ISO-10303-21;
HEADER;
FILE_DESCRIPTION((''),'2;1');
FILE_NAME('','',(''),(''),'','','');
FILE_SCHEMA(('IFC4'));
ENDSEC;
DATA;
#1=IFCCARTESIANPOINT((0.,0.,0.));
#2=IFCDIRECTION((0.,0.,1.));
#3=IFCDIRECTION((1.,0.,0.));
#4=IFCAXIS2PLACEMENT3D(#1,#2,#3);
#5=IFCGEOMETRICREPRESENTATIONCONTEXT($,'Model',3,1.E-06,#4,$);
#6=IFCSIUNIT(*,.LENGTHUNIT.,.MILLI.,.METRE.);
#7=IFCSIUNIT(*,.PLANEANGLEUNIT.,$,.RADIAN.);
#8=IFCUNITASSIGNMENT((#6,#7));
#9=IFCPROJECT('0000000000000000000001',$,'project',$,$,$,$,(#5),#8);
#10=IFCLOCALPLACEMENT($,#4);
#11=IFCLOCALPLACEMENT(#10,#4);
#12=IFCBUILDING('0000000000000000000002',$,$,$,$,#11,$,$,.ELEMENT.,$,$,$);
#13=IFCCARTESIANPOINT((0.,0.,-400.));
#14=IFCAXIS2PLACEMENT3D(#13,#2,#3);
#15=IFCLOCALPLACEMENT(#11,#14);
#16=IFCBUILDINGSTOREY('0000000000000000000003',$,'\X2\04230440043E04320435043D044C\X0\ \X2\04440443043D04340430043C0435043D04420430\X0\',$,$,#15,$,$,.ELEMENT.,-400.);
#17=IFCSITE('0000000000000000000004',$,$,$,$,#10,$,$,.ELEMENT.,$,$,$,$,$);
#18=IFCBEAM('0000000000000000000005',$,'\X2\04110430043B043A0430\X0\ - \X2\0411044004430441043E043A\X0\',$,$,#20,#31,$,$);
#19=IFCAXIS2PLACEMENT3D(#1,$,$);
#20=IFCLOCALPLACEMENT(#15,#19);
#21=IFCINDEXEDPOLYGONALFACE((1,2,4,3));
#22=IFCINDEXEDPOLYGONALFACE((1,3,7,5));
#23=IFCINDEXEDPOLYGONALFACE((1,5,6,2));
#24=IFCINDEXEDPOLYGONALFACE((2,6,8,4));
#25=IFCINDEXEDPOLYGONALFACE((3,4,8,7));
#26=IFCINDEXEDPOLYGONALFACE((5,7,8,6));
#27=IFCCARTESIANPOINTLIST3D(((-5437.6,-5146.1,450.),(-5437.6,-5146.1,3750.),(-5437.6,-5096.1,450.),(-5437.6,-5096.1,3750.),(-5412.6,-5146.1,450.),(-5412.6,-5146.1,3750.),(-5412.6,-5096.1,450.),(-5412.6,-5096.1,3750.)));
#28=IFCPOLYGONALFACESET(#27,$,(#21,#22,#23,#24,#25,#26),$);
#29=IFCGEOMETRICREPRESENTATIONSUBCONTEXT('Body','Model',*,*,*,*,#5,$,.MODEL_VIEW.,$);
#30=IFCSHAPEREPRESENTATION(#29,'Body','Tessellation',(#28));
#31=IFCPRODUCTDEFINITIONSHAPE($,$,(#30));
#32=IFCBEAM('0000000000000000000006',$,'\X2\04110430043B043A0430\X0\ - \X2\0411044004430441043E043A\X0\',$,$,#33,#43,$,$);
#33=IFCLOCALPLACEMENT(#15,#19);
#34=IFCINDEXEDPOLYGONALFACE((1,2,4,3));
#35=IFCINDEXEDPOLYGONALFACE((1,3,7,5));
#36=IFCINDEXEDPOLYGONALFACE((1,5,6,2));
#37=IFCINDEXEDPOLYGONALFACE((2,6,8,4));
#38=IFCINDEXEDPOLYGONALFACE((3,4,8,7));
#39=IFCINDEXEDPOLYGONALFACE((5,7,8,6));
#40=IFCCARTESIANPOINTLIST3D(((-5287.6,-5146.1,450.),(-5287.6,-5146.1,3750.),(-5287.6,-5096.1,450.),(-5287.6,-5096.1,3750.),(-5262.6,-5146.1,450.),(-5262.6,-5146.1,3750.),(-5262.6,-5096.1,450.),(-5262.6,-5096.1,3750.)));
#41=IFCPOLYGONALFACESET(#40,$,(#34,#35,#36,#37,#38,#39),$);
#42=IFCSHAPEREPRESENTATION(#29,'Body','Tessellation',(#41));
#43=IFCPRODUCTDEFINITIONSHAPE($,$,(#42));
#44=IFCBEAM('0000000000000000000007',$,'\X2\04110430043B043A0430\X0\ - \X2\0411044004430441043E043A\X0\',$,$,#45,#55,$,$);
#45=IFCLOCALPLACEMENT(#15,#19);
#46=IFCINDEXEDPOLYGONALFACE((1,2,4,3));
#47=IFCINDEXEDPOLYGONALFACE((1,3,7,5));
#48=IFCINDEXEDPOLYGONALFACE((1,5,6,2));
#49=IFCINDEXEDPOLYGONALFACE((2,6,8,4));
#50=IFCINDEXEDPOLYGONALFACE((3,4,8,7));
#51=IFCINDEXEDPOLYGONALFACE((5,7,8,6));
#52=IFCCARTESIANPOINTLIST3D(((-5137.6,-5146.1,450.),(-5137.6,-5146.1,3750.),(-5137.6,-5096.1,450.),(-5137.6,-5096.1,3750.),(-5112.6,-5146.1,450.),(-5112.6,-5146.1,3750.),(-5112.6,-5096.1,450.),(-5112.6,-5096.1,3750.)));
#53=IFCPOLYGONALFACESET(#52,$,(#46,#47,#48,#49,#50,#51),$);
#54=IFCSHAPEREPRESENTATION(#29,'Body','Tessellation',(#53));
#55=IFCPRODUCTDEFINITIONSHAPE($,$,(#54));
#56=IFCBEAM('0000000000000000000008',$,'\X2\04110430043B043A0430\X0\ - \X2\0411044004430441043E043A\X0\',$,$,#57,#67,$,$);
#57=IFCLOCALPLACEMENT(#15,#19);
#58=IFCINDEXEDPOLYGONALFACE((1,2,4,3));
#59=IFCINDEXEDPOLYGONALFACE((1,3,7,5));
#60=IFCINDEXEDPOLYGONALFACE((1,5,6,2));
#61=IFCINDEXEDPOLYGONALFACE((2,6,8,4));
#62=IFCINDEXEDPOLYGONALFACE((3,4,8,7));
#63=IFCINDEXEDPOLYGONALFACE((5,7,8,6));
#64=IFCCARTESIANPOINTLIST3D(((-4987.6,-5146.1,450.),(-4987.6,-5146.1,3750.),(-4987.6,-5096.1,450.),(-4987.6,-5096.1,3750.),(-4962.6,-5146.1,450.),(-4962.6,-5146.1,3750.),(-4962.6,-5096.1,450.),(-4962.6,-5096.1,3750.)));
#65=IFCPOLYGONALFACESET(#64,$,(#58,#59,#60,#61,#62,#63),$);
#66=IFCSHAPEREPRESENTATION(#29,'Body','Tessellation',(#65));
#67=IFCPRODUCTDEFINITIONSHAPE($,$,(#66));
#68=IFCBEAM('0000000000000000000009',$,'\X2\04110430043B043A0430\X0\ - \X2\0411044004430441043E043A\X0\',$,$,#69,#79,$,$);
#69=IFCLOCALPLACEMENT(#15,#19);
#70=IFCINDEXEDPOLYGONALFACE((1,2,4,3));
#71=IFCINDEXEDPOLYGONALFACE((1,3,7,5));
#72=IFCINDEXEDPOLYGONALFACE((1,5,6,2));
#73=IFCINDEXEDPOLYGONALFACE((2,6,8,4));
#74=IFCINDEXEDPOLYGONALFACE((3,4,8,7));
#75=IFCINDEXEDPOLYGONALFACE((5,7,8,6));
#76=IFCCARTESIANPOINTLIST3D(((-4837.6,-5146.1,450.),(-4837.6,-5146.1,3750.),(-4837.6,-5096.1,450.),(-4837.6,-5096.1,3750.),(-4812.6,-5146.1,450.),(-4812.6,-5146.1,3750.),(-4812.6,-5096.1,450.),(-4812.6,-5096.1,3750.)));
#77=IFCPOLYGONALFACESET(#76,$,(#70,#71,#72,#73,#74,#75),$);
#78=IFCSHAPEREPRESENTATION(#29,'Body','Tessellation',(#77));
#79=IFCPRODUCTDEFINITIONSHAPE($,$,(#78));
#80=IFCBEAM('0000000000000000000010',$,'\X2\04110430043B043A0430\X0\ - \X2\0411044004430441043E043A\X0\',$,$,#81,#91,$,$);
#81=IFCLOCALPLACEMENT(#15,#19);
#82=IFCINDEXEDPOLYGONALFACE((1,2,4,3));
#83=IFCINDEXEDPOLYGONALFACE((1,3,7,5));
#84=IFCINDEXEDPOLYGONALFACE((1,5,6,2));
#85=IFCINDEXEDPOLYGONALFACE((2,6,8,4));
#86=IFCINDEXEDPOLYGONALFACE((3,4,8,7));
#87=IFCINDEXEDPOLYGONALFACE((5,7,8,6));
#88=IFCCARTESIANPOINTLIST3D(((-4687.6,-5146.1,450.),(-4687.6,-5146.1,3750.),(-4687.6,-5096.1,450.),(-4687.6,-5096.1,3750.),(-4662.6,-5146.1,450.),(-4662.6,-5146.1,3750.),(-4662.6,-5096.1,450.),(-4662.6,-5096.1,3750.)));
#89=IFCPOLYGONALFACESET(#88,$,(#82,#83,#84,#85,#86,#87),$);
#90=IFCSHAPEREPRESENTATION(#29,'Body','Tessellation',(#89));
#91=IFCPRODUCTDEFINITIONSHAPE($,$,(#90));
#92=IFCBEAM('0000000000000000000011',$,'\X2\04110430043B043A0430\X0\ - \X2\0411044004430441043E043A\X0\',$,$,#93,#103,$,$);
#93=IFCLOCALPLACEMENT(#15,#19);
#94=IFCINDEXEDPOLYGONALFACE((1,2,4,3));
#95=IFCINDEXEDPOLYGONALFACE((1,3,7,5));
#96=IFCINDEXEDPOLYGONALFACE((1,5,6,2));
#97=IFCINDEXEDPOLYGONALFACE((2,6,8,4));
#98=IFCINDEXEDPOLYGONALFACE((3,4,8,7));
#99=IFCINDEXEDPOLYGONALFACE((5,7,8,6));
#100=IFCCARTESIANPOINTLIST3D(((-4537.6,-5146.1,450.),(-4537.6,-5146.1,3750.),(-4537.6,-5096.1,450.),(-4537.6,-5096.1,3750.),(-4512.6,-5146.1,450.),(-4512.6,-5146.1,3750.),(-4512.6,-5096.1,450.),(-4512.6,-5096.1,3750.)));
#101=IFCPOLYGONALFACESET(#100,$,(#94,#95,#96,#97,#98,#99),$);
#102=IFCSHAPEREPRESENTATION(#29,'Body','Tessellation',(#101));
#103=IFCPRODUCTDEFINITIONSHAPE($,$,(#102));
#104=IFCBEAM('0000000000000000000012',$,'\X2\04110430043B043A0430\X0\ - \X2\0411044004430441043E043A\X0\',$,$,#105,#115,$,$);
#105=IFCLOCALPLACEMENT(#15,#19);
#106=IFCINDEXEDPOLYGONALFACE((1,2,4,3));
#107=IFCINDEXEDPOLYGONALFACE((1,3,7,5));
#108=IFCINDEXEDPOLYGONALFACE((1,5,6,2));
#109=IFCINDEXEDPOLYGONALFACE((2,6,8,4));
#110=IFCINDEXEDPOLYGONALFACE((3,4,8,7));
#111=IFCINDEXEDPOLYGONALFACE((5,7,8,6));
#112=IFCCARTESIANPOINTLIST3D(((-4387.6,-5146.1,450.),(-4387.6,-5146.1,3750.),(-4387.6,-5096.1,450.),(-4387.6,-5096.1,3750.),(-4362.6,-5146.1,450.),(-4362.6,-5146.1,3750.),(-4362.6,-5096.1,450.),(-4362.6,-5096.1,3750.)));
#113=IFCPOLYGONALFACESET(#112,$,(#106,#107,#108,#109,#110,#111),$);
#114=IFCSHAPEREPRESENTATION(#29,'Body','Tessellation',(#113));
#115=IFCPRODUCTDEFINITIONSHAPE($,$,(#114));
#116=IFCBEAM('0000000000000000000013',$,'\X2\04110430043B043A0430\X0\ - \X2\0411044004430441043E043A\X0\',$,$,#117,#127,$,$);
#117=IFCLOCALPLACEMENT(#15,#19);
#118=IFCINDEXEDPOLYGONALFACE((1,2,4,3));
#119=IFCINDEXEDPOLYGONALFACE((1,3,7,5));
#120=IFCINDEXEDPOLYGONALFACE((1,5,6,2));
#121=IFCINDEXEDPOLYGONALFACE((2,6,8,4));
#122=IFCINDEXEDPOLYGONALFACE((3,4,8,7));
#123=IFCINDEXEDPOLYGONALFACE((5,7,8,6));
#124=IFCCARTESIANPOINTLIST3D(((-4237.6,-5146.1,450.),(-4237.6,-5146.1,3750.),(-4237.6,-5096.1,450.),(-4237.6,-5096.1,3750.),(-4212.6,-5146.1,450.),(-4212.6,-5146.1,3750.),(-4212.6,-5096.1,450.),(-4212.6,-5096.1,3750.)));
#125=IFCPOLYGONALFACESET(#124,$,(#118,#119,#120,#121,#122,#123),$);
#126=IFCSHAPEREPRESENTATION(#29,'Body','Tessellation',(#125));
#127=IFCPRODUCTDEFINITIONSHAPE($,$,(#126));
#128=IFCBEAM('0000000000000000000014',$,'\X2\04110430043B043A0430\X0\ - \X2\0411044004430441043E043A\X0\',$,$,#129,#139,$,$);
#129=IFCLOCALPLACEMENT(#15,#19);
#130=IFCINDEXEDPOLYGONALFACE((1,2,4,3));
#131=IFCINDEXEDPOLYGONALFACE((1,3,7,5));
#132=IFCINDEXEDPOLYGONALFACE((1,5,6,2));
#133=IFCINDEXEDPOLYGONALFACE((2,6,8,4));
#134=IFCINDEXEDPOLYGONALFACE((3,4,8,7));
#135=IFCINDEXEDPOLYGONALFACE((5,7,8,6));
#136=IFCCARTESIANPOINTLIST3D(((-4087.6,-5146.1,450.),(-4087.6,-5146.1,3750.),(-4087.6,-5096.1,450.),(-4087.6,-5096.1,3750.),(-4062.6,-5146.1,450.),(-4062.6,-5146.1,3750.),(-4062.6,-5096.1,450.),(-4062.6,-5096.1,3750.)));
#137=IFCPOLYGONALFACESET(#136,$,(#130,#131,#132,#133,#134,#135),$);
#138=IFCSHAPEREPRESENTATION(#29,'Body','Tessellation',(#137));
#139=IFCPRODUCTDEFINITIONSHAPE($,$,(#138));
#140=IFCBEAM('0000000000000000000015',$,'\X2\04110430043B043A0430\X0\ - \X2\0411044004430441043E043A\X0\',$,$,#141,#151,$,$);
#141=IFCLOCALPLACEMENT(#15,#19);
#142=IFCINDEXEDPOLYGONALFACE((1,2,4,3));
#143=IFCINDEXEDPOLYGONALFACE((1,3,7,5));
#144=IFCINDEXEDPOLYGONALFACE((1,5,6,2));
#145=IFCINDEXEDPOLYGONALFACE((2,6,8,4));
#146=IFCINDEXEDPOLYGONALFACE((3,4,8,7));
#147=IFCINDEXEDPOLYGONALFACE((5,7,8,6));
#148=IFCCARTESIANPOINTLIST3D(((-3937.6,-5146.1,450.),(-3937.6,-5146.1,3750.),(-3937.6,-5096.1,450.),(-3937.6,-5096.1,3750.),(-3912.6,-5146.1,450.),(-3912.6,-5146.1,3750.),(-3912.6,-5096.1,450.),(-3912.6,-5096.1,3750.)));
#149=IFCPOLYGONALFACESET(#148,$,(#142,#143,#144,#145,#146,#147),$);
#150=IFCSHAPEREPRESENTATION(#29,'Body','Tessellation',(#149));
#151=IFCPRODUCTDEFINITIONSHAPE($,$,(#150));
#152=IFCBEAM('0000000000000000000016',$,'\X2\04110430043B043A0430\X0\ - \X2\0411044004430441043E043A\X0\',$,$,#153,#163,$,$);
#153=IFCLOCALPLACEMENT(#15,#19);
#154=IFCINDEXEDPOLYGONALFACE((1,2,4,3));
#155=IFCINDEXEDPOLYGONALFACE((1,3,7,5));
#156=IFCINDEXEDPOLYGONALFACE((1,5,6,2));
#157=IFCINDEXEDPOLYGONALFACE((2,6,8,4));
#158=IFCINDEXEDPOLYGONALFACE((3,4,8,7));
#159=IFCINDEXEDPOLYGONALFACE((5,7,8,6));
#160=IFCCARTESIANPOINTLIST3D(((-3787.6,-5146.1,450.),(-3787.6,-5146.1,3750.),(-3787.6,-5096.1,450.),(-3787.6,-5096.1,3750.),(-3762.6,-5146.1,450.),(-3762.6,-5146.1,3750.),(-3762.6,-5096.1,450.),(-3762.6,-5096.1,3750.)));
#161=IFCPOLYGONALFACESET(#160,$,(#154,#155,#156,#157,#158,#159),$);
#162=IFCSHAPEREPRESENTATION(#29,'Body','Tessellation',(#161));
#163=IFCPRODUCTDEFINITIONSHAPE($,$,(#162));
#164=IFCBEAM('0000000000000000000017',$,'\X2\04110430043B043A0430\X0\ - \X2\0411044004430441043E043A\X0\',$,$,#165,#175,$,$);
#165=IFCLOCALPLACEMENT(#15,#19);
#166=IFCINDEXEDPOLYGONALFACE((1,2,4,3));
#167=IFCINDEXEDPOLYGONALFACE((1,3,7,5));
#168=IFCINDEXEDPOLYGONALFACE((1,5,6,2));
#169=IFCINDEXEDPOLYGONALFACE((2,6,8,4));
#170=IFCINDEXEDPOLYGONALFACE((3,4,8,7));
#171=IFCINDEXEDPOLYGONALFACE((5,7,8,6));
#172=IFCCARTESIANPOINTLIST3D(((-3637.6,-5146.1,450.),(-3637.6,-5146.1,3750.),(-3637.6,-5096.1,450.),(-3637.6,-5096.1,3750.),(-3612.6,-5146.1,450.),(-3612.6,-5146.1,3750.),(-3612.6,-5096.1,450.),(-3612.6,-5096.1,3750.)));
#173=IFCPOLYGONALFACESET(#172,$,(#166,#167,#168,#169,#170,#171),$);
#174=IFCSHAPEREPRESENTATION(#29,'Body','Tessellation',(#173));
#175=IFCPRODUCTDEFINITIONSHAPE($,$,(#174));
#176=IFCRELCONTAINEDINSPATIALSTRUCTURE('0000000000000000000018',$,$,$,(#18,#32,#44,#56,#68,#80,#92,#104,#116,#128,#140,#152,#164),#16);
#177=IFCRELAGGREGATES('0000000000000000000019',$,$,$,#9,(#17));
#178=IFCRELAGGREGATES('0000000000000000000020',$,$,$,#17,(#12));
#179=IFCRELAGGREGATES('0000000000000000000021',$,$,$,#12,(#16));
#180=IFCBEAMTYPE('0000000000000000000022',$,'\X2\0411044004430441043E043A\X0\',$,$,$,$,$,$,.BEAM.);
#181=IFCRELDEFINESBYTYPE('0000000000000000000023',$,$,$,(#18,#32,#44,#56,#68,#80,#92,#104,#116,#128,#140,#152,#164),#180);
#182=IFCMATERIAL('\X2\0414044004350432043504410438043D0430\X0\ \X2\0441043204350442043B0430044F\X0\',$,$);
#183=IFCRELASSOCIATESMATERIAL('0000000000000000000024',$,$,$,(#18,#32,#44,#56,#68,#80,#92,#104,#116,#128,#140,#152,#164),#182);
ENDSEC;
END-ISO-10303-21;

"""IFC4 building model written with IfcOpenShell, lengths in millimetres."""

from ifc_helpers import new_model, si_unit, frame, origin_with_axes, place, context, subcontext, project, spatial, line, indexed_curve, outline, extrude, source, transform, mapped, material, type_object, element, save


model = new_model("IFC4")

# Units and contexts
model_context = context("Model", 3, precision=1e-06, world=origin_with_axes())
body_context = subcontext(model_context, "Body", "Model", "MODEL_VIEW")
ifc_project = project(units=[si_unit("LENGTHUNIT", "METRE", prefix="MILLI"), si_unit("PLANEANGLEUNIT", "RADIAN")], contexts=[model_context])

# Site, building, storey
site_placement = place(None, origin_with_axes())
site = spatial("IfcSite", under=ifc_project, at=site_placement, CompositionType="ELEMENT")
building_placement = place(site_placement, origin_with_axes())
building = spatial("IfcBuilding", under=site, at=building_placement, CompositionType="ELEMENT")
storey_placement = place(building_placement, frame((0.0, 0.0, -400.0), z_axis=(0.0, 0.0, 1.0), x_axis=(1.0, 0.0, 0.0)))
storey = spatial("IfcBuildingStorey", under=building, at=storey_placement, Name="Уровень фундамента", CompositionType="ELEMENT", Elevation=-400.0)

# Beams
ifc_material_1 = material(Name="Древесина светлая")
beam_type_1 = type_object("IfcBeamType", Name="Брусок", PredefinedType="BEAM")
shared_shape_1 = source(origin_with_axes(), body_context, "Body", "SweptSolid", [
    extrude(outline(indexed_curve([(0.0, 0.0), (50.0, 0.0), (50.0, 25.0), (0.0, 25.0)], segments=[line(1, 2), line(2, 3), line(3, 4), line(4, 1)])), origin_with_axes(), (0.0, 0.0, -1.0), 3300.0),
])
for number, where, z_axis, x_axis, name in (
    (1, (-5412.6, -5096.1, 450.0), (0.0, 0.0, -1.0), (0.0, -1.0, 0.0), "Балка - Брусок"),
    (2, (-5262.6, -5096.1, 450.0), (0.0, 0.0, -1.0), (0.0, -1.0, 0.0), "Балка - Брусок"),
    (3, (-5112.6, -5096.1, 450.0), (0.0, 0.0, -1.0), (0.0, -1.0, 0.0), "Балка - Брусок"),
    (4, (-4962.6, -5096.1, 450.0), (0.0, 0.0, -1.0), (0.0, -1.0, 0.0), "Балка - Брусок"),
    (5, (-4812.6, -5096.1, 450.0), (0.0, 0.0, -1.0), (0.0, -1.0, 0.0), "Балка - Брусок"),
    (6, (-4662.6, -5096.1, 450.0), (0.0, 0.0, -1.0), (0.0, -1.0, 0.0), "Балка - Брусок"),
    (7, (-4512.6, -5096.1, 450.0), (0.0, 0.0, -1.0), (0.0, -1.0, 0.0), "Балка - Брусок"),
    (8, (-4362.6, -5096.1, 450.0), (0.0, 0.0, -1.0), (0.0, -1.0, 0.0), "Балка - Брусок"),
    (9, (-4212.6, -5096.1, 450.0), (0.0, 0.0, -1.0), (0.0, -1.0, 0.0), "Балка - Брусок"),
    (10, (-4062.6, -5096.1, 450.0), (0.0, 0.0, -1.0), (0.0, -1.0, 0.0), "Балка - Брусок"),
    (11, (-3912.6, -5096.1, 450.0), (0.0, 0.0, -1.0), (0.0, -1.0, 0.0), "Балка - Брусок"),
    (12, (-3762.6, -5096.1, 450.0), (0.0, 0.0, -1.0), (0.0, -1.0, 0.0), "Балка - Брусок"),
    (13, (-3612.6, -5096.1, 450.0), (0.0, 0.0, -1.0), (0.0, -1.0, 0.0), "Балка - Брусок"),
):
    element("IfcBeam", number, at=place(storey_placement, frame(where, z_axis=z_axis, x_axis=x_axis)), inside=storey, type_object=beam_type_1, material=ifc_material_1, Name=name, context=body_context, shape_type="MappedRepresentation", body=[
        mapped(shared_shape_1, transform((0.0, 0.0, 0.0), x_axis=(1.0, 0.0, 0.0), y_axis=(0.0, 1.0, 0.0), z_axis=(0.0, 0.0, 1.0), scale=1.0)),
    ])

save(model, "model.ifc")
